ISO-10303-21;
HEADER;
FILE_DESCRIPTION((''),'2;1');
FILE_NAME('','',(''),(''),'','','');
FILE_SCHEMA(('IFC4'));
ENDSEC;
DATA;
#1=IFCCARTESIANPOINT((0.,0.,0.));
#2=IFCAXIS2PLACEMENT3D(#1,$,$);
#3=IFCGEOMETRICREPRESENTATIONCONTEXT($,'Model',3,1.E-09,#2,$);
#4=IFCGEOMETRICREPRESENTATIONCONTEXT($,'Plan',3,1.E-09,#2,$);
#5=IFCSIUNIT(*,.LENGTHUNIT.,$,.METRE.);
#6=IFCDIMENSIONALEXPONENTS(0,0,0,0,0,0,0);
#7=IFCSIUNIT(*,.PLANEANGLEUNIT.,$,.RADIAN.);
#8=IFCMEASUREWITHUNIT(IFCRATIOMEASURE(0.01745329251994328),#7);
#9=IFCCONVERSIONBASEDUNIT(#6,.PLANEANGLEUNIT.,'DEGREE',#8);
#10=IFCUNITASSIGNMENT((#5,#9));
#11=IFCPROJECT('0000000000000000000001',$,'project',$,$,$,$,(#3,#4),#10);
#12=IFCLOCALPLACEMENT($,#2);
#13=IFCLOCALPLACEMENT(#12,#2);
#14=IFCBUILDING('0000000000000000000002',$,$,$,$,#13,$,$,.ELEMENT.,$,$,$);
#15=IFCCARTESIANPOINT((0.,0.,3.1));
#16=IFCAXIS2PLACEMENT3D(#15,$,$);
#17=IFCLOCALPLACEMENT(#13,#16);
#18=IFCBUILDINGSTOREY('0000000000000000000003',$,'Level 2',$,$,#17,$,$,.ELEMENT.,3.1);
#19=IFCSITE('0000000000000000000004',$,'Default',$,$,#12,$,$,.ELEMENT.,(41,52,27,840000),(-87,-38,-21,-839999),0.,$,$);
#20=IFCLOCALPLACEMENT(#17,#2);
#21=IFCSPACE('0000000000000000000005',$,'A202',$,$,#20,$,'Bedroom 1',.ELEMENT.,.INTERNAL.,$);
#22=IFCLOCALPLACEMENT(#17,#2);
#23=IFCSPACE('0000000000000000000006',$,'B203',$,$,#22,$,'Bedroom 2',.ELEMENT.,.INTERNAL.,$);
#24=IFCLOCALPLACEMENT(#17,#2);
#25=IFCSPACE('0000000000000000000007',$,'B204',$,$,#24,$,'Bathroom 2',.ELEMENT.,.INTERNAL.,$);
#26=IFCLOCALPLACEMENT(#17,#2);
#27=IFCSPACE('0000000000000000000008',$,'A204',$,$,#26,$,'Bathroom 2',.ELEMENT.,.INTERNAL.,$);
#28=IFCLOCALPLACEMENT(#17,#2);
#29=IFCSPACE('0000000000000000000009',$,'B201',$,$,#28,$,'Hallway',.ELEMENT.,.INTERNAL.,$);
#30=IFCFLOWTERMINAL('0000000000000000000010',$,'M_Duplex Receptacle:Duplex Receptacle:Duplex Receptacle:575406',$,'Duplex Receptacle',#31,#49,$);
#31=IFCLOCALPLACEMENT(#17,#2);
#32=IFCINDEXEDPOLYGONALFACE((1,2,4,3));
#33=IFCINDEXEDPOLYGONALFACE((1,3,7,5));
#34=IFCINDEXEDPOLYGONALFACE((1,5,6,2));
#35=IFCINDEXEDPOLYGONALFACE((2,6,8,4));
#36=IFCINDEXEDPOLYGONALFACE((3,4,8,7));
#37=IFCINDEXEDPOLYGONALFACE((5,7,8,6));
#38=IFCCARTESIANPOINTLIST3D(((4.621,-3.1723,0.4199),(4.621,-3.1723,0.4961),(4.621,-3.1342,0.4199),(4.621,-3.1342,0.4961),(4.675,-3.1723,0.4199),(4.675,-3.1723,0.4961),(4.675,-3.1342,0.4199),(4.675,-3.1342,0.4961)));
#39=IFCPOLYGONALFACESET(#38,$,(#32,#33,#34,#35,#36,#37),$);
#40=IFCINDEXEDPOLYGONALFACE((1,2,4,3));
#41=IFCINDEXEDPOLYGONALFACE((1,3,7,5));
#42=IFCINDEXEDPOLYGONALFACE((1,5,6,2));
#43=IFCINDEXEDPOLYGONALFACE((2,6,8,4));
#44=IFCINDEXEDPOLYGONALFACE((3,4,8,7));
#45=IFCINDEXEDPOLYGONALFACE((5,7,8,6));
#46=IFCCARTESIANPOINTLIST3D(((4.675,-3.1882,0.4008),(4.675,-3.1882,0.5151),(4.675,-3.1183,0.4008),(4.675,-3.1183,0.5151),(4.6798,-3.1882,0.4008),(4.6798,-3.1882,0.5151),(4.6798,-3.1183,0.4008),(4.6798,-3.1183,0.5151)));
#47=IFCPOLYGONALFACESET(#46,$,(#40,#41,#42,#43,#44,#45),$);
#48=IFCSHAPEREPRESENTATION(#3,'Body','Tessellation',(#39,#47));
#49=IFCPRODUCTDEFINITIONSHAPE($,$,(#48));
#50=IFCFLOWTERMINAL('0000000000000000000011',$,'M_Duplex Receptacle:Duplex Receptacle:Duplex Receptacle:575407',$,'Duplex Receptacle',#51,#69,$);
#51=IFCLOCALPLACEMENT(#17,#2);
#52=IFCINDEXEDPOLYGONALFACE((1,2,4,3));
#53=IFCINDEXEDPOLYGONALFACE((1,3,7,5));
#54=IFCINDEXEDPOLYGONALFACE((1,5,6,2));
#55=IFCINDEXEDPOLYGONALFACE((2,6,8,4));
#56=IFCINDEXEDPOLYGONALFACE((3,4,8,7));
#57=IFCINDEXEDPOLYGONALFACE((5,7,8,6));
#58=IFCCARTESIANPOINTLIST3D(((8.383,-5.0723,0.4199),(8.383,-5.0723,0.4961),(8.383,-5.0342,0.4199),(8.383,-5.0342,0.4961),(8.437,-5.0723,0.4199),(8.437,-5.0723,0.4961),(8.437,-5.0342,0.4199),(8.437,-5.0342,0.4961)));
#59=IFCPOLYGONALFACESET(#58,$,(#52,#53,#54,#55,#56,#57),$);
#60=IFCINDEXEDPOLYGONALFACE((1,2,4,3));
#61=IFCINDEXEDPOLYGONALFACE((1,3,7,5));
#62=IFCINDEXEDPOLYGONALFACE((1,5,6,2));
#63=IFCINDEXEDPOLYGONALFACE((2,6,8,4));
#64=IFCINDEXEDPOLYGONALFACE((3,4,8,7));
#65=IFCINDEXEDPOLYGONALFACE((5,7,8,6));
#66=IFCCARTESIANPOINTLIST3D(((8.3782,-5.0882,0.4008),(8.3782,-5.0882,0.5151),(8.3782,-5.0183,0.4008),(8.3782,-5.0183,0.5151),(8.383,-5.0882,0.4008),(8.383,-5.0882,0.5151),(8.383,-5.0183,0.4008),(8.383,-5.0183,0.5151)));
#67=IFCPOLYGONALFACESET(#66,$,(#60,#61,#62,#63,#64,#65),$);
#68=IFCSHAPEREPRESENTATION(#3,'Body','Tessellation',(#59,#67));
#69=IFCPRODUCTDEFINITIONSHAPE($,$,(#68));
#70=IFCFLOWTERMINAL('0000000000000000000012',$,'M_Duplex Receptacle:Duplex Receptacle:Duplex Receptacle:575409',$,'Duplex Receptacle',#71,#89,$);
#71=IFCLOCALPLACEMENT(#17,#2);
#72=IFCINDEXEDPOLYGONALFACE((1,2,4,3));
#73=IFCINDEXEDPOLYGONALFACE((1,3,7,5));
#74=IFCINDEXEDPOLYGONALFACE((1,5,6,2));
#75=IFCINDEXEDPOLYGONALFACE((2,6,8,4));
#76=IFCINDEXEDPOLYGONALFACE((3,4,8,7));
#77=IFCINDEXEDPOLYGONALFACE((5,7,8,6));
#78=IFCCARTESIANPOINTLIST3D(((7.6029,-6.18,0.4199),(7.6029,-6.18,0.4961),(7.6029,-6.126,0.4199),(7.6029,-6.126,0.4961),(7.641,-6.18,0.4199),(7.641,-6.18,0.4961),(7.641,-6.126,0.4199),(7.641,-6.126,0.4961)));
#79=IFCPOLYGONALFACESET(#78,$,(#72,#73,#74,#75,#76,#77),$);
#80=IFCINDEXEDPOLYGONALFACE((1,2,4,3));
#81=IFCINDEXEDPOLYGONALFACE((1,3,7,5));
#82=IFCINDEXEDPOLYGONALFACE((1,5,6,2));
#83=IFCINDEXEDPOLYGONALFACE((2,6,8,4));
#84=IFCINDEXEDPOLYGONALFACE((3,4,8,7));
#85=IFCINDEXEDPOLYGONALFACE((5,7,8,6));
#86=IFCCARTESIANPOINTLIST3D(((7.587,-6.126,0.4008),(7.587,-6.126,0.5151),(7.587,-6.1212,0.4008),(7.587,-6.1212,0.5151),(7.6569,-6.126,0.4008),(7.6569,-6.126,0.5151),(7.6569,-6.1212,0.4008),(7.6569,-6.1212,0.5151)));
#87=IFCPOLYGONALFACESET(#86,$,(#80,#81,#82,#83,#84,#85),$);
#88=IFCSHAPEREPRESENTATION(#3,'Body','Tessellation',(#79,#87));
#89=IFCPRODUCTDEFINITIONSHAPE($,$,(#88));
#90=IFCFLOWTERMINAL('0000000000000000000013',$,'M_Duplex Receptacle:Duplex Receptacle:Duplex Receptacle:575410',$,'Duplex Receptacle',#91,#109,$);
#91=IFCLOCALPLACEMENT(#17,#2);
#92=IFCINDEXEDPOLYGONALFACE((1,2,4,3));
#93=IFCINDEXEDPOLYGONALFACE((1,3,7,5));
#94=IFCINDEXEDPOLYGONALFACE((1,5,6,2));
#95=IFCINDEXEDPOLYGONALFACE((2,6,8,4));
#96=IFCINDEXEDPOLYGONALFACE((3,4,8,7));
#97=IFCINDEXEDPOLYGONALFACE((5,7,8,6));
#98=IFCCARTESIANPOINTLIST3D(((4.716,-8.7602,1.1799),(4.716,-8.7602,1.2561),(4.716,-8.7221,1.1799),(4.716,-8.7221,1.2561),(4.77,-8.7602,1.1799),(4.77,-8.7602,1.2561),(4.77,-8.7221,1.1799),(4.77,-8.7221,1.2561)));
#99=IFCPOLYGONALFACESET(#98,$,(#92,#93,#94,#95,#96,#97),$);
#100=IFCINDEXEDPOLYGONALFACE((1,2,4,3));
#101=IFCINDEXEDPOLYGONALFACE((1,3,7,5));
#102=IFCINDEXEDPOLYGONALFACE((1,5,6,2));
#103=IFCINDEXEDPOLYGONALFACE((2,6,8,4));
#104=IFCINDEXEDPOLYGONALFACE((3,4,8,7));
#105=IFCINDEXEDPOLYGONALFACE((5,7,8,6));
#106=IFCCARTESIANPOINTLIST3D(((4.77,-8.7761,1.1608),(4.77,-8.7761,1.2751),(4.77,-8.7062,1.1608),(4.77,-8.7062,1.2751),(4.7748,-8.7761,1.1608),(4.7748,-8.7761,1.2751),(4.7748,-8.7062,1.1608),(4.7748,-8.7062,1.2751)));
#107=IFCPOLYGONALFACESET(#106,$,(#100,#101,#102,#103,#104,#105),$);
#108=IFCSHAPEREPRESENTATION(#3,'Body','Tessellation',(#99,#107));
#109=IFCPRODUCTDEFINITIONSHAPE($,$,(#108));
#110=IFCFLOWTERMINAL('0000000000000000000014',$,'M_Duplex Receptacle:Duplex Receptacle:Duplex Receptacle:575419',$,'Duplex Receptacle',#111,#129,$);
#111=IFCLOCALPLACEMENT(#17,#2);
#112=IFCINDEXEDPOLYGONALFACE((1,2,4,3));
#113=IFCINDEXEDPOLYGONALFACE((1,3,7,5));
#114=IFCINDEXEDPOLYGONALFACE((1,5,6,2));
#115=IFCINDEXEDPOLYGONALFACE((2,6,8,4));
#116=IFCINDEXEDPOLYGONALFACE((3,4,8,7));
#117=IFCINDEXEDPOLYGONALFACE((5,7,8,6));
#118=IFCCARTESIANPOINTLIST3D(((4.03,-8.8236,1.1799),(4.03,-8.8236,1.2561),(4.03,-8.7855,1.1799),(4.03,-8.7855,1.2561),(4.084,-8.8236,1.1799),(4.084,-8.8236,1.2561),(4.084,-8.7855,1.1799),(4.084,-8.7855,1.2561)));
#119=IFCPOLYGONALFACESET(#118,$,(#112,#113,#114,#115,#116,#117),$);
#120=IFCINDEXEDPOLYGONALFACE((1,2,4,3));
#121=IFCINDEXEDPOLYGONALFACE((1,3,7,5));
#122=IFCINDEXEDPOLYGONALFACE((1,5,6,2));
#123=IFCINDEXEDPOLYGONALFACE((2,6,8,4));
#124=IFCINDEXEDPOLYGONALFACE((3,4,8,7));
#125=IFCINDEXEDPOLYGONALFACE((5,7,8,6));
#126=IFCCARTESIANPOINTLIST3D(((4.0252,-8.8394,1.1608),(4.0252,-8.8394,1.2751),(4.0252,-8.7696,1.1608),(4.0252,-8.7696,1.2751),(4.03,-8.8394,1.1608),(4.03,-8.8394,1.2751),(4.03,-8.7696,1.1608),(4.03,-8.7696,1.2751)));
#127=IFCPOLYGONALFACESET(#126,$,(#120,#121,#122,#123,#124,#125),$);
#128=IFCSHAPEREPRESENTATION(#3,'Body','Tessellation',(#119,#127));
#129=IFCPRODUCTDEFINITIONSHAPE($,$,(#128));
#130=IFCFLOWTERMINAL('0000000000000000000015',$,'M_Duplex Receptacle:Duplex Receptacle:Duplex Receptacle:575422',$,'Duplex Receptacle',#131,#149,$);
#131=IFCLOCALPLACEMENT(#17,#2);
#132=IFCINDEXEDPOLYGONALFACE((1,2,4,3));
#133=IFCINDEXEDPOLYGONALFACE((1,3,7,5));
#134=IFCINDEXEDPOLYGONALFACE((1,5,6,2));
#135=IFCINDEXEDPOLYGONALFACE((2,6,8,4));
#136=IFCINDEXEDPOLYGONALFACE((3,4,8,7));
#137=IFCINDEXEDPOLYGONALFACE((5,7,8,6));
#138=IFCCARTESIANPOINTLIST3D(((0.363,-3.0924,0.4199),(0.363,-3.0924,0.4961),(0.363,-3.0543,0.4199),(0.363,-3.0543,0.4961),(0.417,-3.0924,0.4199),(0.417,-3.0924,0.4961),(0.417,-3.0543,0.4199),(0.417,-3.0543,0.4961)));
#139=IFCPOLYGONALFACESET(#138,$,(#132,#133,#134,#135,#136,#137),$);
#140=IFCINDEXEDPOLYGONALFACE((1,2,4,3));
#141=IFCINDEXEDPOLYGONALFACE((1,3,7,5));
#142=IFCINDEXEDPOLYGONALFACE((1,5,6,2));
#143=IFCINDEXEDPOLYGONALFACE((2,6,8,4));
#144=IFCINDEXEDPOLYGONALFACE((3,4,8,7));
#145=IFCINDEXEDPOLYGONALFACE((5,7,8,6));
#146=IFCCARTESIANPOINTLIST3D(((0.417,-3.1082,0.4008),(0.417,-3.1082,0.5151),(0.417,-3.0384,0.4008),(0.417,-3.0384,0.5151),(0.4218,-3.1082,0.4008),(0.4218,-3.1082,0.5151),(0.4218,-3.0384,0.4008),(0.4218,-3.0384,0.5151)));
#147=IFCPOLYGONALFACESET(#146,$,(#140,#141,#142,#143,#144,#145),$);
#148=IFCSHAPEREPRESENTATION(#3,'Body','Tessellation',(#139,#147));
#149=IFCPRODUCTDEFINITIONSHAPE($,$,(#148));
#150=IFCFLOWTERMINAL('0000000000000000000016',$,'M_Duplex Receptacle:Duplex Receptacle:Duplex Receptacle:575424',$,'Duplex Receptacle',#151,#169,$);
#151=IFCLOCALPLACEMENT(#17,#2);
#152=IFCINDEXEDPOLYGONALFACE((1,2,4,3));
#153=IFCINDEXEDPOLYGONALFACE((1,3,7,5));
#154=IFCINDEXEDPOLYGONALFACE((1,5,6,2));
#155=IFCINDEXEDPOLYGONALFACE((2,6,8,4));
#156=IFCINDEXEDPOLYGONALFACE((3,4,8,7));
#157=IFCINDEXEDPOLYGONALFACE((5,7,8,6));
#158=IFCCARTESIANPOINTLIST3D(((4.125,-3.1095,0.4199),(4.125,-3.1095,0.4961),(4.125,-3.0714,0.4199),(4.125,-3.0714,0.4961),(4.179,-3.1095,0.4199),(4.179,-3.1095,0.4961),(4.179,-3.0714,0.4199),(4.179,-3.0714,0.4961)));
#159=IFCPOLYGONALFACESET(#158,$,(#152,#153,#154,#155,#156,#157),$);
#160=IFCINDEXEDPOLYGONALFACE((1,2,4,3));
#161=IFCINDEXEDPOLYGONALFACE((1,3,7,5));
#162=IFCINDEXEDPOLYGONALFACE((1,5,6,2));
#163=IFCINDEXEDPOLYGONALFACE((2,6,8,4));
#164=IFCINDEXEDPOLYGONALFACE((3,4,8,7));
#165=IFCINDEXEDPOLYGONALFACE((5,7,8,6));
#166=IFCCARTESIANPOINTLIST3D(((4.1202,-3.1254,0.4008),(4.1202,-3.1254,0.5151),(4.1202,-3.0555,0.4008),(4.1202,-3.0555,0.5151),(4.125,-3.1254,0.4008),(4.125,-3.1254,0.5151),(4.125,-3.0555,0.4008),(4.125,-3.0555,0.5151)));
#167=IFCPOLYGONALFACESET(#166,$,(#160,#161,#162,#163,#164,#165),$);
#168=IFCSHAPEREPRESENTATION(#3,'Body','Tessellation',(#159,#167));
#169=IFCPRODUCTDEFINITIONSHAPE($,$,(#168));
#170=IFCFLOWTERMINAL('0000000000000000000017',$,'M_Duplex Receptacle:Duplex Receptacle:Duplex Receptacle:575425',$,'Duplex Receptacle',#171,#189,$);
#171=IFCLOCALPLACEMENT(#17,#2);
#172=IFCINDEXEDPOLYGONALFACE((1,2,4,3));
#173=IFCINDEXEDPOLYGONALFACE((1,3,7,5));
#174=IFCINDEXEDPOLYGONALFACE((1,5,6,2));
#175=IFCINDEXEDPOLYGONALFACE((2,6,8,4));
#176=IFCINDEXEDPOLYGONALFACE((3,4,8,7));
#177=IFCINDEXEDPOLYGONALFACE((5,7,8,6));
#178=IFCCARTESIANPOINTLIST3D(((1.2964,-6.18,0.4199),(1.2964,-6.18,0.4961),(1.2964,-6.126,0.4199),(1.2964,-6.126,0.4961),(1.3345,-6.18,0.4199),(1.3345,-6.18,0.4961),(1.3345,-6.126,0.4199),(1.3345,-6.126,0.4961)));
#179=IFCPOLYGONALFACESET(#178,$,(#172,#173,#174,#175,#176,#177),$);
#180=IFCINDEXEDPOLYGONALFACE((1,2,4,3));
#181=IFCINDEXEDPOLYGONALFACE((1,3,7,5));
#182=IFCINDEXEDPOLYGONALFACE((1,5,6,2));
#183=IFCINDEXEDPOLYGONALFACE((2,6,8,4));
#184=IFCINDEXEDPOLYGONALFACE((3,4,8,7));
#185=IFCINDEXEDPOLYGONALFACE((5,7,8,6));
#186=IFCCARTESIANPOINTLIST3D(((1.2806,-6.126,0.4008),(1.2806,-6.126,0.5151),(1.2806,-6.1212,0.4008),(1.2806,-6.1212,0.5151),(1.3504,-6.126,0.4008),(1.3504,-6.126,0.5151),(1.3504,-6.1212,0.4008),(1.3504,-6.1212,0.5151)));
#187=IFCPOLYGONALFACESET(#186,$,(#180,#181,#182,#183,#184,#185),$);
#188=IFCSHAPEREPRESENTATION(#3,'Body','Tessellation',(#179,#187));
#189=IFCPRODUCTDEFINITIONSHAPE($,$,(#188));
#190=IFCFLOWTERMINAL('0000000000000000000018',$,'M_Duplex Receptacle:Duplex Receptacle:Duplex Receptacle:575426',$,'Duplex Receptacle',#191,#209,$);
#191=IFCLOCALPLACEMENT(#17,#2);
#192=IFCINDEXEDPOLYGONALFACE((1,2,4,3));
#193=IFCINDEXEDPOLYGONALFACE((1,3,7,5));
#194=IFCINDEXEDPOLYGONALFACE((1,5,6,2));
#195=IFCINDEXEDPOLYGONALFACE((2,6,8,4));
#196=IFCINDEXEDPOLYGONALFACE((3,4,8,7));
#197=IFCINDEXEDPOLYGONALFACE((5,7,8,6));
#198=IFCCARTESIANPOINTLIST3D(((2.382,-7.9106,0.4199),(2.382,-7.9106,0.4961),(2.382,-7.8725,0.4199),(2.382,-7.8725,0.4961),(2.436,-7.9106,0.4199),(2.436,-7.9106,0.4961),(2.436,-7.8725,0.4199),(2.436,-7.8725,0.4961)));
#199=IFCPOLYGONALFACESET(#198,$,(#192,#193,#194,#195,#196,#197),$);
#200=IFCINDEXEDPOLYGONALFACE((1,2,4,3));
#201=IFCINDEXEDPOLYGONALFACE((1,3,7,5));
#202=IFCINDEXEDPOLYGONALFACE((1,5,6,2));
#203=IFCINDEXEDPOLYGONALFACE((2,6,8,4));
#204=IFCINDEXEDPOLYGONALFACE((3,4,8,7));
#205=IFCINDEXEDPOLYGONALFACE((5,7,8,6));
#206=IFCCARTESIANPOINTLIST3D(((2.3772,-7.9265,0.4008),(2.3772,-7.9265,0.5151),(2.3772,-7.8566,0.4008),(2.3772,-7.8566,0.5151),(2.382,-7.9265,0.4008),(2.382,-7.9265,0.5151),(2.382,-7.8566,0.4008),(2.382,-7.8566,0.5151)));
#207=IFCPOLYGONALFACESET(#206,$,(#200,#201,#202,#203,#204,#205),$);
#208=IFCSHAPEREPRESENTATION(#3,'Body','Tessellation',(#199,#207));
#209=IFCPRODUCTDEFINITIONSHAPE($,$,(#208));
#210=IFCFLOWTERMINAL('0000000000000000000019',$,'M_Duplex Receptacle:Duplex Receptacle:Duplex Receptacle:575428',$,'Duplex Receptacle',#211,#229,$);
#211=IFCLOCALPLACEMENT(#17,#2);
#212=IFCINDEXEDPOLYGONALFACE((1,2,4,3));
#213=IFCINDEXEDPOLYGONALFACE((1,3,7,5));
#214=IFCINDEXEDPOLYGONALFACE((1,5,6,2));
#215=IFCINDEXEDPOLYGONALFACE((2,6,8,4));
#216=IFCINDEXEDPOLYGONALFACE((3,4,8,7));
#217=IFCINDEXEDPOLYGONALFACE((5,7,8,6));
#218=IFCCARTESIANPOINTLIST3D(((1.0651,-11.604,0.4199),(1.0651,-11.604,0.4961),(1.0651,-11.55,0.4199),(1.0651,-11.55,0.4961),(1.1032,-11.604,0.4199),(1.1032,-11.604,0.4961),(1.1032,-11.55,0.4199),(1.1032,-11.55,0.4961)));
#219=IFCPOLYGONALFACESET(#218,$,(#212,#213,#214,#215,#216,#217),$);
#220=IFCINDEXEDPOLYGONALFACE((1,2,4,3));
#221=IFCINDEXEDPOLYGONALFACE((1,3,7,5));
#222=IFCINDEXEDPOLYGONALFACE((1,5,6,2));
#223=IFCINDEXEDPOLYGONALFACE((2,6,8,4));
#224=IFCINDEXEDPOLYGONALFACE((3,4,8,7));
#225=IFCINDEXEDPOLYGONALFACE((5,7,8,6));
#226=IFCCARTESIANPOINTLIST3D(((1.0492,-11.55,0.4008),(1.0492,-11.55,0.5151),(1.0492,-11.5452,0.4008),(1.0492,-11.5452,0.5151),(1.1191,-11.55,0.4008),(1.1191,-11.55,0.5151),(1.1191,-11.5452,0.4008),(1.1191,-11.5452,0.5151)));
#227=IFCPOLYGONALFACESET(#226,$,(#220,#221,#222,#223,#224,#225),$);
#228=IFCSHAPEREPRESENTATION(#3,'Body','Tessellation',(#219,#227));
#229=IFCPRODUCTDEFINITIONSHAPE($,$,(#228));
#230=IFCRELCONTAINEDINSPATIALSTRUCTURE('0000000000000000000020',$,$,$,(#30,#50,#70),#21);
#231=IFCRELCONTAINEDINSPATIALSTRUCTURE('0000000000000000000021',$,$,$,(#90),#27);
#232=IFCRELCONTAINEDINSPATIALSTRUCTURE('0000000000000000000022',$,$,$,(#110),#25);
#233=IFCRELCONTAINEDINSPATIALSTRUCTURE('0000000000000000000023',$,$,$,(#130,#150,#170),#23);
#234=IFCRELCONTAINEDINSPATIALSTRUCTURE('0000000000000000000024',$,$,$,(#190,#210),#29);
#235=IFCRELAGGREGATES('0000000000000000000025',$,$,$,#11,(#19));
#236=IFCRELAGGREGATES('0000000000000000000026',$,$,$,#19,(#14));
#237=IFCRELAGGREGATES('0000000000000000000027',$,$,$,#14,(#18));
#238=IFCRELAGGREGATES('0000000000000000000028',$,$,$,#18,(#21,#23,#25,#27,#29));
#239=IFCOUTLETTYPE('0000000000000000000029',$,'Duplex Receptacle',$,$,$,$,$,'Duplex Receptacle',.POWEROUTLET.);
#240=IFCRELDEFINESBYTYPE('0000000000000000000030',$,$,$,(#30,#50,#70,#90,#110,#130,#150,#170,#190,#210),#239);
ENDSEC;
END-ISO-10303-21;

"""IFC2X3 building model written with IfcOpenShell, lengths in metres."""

from ifc_helpers import new_model, entity, si_unit, converted_unit, frame, origin, origin_2d_with_axis, place, context, project, spatial, rectangle, extrude, source, transform, mapped, type_object, type_shapes, element, save


model = new_model("IFC2X3")

# Units and contexts
model_context = context("Model", 3, precision=1e-09, world=origin())
plan_context = context("Plan", 3, precision=1e-09, world=origin())
ifc_project = project(units=[si_unit("LENGTHUNIT", "METRE"), converted_unit("PLANEANGLEUNIT", "DEGREE", entity("IfcRatioMeasure", 0.01745329251994328), si_unit("PLANEANGLEUNIT", "RADIAN"), dimensions=[0, 0, 0, 0, 0, 0, 0])], contexts=[model_context, plan_context])

# Site, building, storey, space
site_placement = place(None, origin())
site = spatial("IfcSite", under=ifc_project, at=site_placement, Name="Default", CompositionType="ELEMENT", RefLatitude=(41, 52, 27, 840000), RefLongitude=(-87, -38, -21, -839999), RefElevation=0.0)
building_placement = place(site_placement, origin())
building = spatial("IfcBuilding", under=site, at=building_placement, CompositionType="ELEMENT")
storey_placement = place(building_placement, frame((0.0, 0.0, 3.1)))
storey = spatial("IfcBuildingStorey", under=building, at=storey_placement, Name="Level 2", CompositionType="ELEMENT", Elevation=3.1)
space_1_placement = place(storey_placement, origin())
space_1 = spatial("IfcSpace", under=storey, at=space_1_placement, Name="A202", LongName="Bedroom 1", CompositionType="ELEMENT", InteriorOrExteriorSpace="INTERNAL")

# Shared definitions
space_2_placement = place(storey_placement, origin())
space_2 = spatial("IfcSpace", under=storey, at=space_2_placement, Name="B203", LongName="Bedroom 2", CompositionType="ELEMENT", InteriorOrExteriorSpace="INTERNAL")

# Shared definitions
space_3_placement = place(storey_placement, origin())
space_3 = spatial("IfcSpace", under=storey, at=space_3_placement, Name="B204", LongName="Bathroom 2", CompositionType="ELEMENT", InteriorOrExteriorSpace="INTERNAL")

# Shared definitions
space_4_placement = place(storey_placement, origin())
space_4 = spatial("IfcSpace", under=storey, at=space_4_placement, Name="A204", LongName="Bathroom 2", CompositionType="ELEMENT", InteriorOrExteriorSpace="INTERNAL")

# Shared definitions
space_5_placement = place(storey_placement, origin())
space_5 = spatial("IfcSpace", under=storey, at=space_5_placement, Name="B201", LongName="Hallway", CompositionType="ELEMENT", InteriorOrExteriorSpace="INTERNAL")

# Flow terminals
outlet_type = type_object("IfcOutletType", Name="Duplex Receptacle", ElementType="Duplex Receptacle", PredefinedType="POWEROUTLET")
shared_shape_1 = source(origin(), model_context, "Body", "SweptSolid", [
    extrude(rectangle(XDim=0.0381, YDim=0.0762, at=origin_2d_with_axis()), frame((0.0, 0.0, -0.054), z_axis=(0.0, 0.0, 1.0), x_axis=(-1.0, 0.0, 0.0)), (0.0, 0.0, 1.0), 0.054),
    extrude(rectangle(XDim=0.0698, YDim=0.1143, at=origin_2d_with_axis()), frame((0.0, 0.0, 0.0), z_axis=(0.0, 0.0, 1.0), x_axis=(-1.0, 0.0, 0.0)), (0.0, 0.0, 1.0), 0.0048),
])
type_shapes(outlet_type, [shared_shape_1])
for number, where, z_axis, x_axis, name in (
    (1, (4.675, -3.1533, 0.458), (1.0, 0.0, 0.0), (0.0, 1.0, 0.0), "M_Duplex Receptacle:Duplex Receptacle:Duplex Receptacle:575406"),
    (2, (8.383, -5.0533, 0.458), (-1.0, 0.0, 0.0), (0.0, -1.0, 0.0), "M_Duplex Receptacle:Duplex Receptacle:Duplex Receptacle:575407"),
    (3, (7.622, -6.126, 0.458), (0.0, 1.0, 0.0), (-1.0, 0.0, 0.0), "M_Duplex Receptacle:Duplex Receptacle:Duplex Receptacle:575409"),
):
    element("IfcFlowTerminal", number, at=place(space_1_placement, frame(where, z_axis=z_axis, x_axis=x_axis)), inside=space_1, type_object=outlet_type, Name=name, ObjectType="Duplex Receptacle", context=model_context, shape_type="MappedRepresentation", body=[
        mapped(shared_shape_1, transform((0.0, 0.0, 0.0), scale=1.0)),
    ])
flow_terminal_1_placement = place(space_4_placement, frame((4.77, -8.7412, 1.218), z_axis=(1.0, 0.0, 0.0), x_axis=(0.0, 1.0, 0.0)))
element("IfcFlowTerminal", 4, at=flow_terminal_1_placement, inside=space_4, type_object=outlet_type, Name="M_Duplex Receptacle:Duplex Receptacle:Duplex Receptacle:575410", ObjectType="Duplex Receptacle", context=model_context, shape_type="MappedRepresentation", body=[
    mapped(shared_shape_1, transform((0.0, 0.0, 0.0), scale=1.0)),
])
flow_terminal_2_placement = place(space_3_placement, frame((4.03, -8.8045, 1.218), z_axis=(-1.0, 0.0, 0.0), x_axis=(0.0, -1.0, 0.0)))
element("IfcFlowTerminal", 5, at=flow_terminal_2_placement, inside=space_3, type_object=outlet_type, Name="M_Duplex Receptacle:Duplex Receptacle:Duplex Receptacle:575419", ObjectType="Duplex Receptacle", context=model_context, shape_type="MappedRepresentation", body=[
    mapped(shared_shape_1, transform((0.0, 0.0, 0.0), scale=1.0)),
])
for number, where, z_axis, x_axis, name in (
    (6, (0.417, -3.0733, 0.458), (1.0, 0.0, 0.0), (0.0, 1.0, 0.0), "M_Duplex Receptacle:Duplex Receptacle:Duplex Receptacle:575422"),
    (7, (4.125, -3.0905, 0.458), (-1.0, 0.0, 0.0), (0.0, -1.0, 0.0), "M_Duplex Receptacle:Duplex Receptacle:Duplex Receptacle:575424"),
    (8, (1.3155, -6.126, 0.458), (0.0, 1.0, 0.0), (-1.0, 0.0, 0.0), "M_Duplex Receptacle:Duplex Receptacle:Duplex Receptacle:575425"),
):
    element("IfcFlowTerminal", number, at=place(space_2_placement, frame(where, z_axis=z_axis, x_axis=x_axis)), inside=space_2, type_object=outlet_type, Name=name, ObjectType="Duplex Receptacle", context=model_context, shape_type="MappedRepresentation", body=[
        mapped(shared_shape_1, transform((0.0, 0.0, 0.0), scale=1.0)),
    ])
for number, where, z_axis, x_axis, name in (
    (9, (2.382, -7.8916, 0.458), (-1.0, 0.0, 0.0), (0.0, -1.0, 0.0), "M_Duplex Receptacle:Duplex Receptacle:Duplex Receptacle:575426"),
    (10, (1.0841, -11.55, 0.458), (0.0, 1.0, 0.0), (-1.0, 0.0, 0.0), "M_Duplex Receptacle:Duplex Receptacle:Duplex Receptacle:575428"),
):
    element("IfcFlowTerminal", number, at=place(space_5_placement, frame(where, z_axis=z_axis, x_axis=x_axis)), inside=space_5, type_object=outlet_type, Name=name, ObjectType="Duplex Receptacle", context=model_context, shape_type="MappedRepresentation", body=[
        mapped(shared_shape_1, transform((0.0, 0.0, 0.0), scale=1.0)),
    ])

save(model, "model.ifc")
